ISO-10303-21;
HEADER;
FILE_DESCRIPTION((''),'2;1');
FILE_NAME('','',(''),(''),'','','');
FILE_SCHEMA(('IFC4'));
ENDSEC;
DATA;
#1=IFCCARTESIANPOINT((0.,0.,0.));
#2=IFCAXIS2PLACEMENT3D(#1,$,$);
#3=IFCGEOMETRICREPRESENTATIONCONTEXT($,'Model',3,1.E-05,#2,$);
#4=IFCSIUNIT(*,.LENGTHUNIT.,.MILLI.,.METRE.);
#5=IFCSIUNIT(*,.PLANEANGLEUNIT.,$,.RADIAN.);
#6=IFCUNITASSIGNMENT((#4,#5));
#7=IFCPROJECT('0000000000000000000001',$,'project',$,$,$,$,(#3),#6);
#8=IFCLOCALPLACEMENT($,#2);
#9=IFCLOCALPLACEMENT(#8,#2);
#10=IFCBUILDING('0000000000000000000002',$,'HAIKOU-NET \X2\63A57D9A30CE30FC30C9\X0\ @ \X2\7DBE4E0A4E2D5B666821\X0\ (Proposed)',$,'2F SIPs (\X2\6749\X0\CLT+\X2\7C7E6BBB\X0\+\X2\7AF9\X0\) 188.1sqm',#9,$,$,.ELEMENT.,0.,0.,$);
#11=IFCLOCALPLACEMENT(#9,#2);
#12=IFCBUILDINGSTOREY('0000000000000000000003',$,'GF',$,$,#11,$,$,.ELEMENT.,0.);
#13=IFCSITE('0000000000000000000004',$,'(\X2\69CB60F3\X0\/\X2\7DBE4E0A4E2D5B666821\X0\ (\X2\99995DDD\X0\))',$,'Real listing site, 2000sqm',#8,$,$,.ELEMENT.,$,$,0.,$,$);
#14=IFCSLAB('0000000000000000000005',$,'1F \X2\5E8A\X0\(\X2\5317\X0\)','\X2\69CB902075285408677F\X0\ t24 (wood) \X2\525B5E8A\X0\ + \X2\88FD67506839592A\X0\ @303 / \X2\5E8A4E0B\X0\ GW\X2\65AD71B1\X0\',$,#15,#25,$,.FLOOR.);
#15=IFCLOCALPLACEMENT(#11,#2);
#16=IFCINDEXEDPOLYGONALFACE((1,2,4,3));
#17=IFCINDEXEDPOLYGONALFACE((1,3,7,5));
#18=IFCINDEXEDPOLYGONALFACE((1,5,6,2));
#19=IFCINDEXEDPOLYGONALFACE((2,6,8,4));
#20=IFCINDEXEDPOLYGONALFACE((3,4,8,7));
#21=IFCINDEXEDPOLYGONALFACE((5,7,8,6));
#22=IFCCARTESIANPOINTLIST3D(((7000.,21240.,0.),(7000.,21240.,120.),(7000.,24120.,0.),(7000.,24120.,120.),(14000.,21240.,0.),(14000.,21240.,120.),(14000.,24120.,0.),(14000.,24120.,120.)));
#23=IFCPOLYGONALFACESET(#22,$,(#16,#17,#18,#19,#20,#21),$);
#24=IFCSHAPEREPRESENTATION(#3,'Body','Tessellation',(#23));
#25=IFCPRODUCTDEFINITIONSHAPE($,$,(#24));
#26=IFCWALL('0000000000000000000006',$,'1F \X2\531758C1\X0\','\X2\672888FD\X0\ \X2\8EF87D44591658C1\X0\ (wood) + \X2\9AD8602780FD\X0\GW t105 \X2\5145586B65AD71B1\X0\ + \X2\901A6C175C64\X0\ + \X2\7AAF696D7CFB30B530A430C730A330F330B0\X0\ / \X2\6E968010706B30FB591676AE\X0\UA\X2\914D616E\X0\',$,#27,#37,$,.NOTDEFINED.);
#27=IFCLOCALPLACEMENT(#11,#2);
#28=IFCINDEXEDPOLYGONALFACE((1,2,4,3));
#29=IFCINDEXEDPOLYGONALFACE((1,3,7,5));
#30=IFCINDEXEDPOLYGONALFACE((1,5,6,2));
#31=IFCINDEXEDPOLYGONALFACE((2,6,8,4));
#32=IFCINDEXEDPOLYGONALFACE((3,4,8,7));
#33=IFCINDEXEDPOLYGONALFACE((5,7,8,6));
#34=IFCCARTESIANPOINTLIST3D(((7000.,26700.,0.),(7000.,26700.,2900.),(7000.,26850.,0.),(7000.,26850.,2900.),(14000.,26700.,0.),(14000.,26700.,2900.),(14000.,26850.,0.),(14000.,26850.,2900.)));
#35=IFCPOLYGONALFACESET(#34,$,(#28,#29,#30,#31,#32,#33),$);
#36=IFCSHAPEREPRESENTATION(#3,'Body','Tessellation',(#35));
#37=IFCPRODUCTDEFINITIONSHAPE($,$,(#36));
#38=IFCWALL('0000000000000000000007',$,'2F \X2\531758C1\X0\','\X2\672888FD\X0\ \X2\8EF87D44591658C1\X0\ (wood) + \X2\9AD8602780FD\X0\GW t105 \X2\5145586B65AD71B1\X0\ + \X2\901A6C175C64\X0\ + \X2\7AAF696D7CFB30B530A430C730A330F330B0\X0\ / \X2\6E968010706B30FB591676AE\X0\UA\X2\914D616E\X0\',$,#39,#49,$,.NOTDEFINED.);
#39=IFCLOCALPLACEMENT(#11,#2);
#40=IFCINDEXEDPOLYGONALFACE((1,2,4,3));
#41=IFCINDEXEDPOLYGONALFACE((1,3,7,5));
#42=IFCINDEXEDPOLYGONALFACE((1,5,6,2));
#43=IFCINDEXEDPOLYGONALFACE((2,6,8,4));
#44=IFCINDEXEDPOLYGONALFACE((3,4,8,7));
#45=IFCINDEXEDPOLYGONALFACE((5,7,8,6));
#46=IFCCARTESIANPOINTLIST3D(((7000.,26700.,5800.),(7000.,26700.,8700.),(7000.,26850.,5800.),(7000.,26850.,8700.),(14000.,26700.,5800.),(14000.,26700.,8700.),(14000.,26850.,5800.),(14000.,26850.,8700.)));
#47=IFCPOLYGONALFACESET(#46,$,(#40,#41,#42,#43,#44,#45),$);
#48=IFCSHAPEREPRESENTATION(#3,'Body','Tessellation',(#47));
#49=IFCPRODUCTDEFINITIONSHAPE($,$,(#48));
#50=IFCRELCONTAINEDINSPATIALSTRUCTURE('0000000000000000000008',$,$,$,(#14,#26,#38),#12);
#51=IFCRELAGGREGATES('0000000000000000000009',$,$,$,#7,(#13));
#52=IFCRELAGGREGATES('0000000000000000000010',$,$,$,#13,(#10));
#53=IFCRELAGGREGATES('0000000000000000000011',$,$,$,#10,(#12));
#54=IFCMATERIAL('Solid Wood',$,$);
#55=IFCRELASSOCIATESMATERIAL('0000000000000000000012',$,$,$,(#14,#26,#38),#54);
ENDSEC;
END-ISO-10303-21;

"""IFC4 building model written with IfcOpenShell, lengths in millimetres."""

from ifc_helpers import new_model, si_unit, frame, frame_2d, origin, place, context, project, spatial, rectangle, extrude, material, element, save


model = new_model("IFC4")

# Units and contexts
model_context = context("Model", 3, precision=1e-05, world=origin())
ifc_project = project(units=[si_unit("LENGTHUNIT", "METRE", prefix="MILLI"), si_unit("PLANEANGLEUNIT", "RADIAN")], contexts=[model_context])

# Site, building, storey
site_placement = place(None, origin())
site = spatial("IfcSite", under=ifc_project, at=site_placement, Name="(構想/綾上中学校 (香川))", ObjectType="Real listing site, 2000sqm", CompositionType="ELEMENT", RefElevation=0.0)
building_placement = place(site_placement, origin())
building = spatial("IfcBuilding", under=site, at=building_placement, Name="HAIKOU-NET 接続ノード @ 綾上中学校 (Proposed)", ObjectType="2F SIPs (杉CLT+籾殻+竹) 188.1sqm", CompositionType="ELEMENT", ElevationOfRefHeight=0.0, ElevationOfTerrain=0.0)
storey_placement = place(building_placement, origin())
storey = spatial("IfcBuildingStorey", under=building, at=storey_placement, Name="GF", CompositionType="ELEMENT", Elevation=0.0)

# Slab
ifc_material_1 = material(Name="Solid Wood")
slab_1_placement = place(storey_placement, frame((3500.0, 10620.0, 0.0)))
element("IfcSlab", 1, at=slab_1_placement, inside=storey, material=ifc_material_1, Name="1F 床(北)", Description="構造用合板 t24 (wood) 剛床 + 製材根太 @303 / 床下 GW断熱", PredefinedType="FLOOR", context=model_context, shape_type="SweptSolid", body=[
    extrude(rectangle(XDim=7000.0, YDim=2880.0, at=frame_2d((3500.0, 1440.0))), frame((3500.0, 10620.0, 0.0)), (0.0, 0.0, 1.0), 120.0),
])

# Wall
wall_1_placement = place(storey_placement, frame((3500.0, 13350.0, 0.0)))
element("IfcWall", 2, at=wall_1_placement, inside=storey, material=ifc_material_1, Name="1F 北壁", Description="木製 軸組外壁 (wood) + 高性能GW t105 充填断熱 + 通気層 + 窯業系サイディング / 準耐火・外皮UA配慮", PredefinedType="NOTDEFINED", context=model_context, shape_type="SweptSolid", body=[
    extrude(rectangle(XDim=7000.0, YDim=150.0, at=frame_2d((3500.0, 75.0))), frame((3500.0, 13350.0, 0.0)), (0.0, 0.0, 1.0), 2900.0),
])

# Wall
wall_2_placement = place(storey_placement, frame((3500.0, 13350.0, 2900.0)))
element("IfcWall", 3, at=wall_2_placement, inside=storey, material=ifc_material_1, Name="2F 北壁", Description="木製 軸組外壁 (wood) + 高性能GW t105 充填断熱 + 通気層 + 窯業系サイディング / 準耐火・外皮UA配慮", PredefinedType="NOTDEFINED", context=model_context, shape_type="SweptSolid", body=[
    extrude(rectangle(XDim=7000.0, YDim=150.0, at=frame_2d((3500.0, 75.0))), frame((3500.0, 13350.0, 2900.0)), (0.0, 0.0, 1.0), 2900.0),
])

save(model, "model.ifc")
